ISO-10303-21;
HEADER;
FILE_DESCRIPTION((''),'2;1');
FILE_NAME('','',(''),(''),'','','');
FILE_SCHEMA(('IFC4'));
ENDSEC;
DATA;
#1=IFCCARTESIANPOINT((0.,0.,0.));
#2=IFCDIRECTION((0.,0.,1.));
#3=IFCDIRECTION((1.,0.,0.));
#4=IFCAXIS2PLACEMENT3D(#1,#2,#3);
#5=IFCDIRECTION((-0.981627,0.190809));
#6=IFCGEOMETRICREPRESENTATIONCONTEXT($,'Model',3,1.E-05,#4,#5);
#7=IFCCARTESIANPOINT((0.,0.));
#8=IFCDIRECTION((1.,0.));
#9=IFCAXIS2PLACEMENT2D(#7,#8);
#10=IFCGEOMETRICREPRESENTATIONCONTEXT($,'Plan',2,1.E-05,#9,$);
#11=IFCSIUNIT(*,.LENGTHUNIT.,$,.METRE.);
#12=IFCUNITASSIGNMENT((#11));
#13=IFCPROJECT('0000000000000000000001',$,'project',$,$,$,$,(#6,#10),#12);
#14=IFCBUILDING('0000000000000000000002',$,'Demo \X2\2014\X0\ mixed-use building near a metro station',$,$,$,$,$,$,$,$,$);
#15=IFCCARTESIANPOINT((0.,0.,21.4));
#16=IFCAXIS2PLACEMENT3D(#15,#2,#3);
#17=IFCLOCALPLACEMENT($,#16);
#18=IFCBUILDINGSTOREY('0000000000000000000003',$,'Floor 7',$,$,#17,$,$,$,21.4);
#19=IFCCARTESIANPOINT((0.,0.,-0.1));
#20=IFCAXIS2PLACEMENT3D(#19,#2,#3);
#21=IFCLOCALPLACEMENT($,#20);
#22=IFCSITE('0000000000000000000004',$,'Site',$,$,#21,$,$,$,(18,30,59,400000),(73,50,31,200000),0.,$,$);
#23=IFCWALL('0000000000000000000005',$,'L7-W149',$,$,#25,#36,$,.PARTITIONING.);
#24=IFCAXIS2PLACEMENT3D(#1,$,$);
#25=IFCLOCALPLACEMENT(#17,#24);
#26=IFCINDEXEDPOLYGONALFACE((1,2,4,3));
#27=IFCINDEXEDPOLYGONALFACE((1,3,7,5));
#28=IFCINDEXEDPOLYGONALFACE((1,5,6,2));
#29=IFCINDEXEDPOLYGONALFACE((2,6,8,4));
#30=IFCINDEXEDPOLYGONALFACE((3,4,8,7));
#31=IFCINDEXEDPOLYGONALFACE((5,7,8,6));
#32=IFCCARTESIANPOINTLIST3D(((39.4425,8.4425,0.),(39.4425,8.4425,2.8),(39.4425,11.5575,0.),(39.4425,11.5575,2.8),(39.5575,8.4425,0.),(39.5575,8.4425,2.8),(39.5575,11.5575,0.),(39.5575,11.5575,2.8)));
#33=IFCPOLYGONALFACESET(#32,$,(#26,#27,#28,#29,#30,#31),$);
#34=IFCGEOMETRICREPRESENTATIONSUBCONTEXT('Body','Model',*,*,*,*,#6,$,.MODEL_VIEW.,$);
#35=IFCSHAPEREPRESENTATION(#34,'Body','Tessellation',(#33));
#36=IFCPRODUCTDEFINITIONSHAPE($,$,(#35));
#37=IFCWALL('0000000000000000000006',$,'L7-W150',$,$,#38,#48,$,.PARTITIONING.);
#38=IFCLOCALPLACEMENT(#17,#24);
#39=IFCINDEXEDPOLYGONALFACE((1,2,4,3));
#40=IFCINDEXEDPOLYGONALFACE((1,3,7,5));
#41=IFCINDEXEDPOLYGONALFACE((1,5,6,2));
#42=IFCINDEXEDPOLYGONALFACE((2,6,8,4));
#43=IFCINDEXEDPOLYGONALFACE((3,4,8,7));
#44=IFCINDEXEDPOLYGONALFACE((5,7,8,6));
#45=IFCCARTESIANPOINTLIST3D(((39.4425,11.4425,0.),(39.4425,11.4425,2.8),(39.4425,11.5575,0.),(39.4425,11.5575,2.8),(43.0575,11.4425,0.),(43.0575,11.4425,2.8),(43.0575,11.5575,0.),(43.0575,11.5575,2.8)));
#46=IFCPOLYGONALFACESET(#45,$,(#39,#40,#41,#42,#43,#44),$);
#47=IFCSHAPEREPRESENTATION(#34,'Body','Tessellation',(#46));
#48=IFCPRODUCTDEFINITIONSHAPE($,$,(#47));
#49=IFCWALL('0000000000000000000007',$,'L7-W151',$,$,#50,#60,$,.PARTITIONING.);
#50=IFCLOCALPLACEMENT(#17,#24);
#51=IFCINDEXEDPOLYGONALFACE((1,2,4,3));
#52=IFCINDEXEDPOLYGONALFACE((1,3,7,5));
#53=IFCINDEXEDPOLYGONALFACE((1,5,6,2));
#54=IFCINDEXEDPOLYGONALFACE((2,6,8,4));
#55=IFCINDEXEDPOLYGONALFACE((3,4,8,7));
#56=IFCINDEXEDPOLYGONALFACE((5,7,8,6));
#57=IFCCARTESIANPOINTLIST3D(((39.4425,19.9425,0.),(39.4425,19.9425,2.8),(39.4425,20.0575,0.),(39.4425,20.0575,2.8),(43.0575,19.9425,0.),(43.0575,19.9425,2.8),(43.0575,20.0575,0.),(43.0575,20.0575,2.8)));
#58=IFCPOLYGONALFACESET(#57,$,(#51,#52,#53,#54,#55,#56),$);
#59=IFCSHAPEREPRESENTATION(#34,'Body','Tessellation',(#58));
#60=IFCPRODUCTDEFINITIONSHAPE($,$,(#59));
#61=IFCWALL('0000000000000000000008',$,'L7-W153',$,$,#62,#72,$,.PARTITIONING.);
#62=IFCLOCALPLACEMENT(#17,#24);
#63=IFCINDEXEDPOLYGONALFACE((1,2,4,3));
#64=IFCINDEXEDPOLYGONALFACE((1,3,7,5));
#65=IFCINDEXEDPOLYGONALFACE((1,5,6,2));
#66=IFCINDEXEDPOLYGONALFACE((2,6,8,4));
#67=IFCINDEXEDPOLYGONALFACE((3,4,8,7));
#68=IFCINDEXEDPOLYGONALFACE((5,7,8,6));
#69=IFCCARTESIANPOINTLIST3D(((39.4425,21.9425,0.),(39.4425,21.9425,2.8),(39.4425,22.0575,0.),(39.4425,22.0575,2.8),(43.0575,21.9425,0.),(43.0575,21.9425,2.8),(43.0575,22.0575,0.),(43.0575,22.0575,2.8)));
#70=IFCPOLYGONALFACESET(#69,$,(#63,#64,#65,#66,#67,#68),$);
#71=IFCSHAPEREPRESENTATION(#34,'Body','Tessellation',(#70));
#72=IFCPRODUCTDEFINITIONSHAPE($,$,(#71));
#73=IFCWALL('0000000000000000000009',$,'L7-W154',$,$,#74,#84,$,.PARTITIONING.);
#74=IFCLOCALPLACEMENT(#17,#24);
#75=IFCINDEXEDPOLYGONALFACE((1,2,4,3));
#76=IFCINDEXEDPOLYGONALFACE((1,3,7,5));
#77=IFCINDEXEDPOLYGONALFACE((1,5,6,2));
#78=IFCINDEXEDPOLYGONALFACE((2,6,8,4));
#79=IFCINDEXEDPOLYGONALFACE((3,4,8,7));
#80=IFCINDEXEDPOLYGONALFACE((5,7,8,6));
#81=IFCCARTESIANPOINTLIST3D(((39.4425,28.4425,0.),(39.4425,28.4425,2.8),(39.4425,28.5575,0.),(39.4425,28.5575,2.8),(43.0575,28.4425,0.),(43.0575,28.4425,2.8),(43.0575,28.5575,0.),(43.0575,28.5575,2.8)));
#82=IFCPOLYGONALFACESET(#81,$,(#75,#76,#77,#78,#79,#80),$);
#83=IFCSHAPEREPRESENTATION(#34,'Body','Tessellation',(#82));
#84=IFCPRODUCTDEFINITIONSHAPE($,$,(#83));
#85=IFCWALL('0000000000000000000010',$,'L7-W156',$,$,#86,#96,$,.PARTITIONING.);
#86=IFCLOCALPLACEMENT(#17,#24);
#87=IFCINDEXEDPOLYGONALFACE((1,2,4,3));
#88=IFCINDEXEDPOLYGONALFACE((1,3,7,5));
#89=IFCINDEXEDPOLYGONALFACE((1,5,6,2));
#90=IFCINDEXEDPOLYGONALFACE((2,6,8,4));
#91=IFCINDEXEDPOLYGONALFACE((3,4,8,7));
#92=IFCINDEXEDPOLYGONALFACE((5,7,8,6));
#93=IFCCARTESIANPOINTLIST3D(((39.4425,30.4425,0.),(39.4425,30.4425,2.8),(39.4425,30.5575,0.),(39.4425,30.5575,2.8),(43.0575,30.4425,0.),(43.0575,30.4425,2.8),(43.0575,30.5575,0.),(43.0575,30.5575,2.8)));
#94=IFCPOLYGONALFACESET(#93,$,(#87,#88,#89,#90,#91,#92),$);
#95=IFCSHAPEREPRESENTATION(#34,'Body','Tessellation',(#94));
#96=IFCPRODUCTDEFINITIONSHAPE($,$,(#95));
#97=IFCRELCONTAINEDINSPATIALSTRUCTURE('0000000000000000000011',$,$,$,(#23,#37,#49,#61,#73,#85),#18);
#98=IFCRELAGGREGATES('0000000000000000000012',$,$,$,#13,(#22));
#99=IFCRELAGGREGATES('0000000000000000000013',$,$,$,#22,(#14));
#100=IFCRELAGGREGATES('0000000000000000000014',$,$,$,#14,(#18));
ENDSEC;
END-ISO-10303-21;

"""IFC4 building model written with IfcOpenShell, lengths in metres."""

from ifc_helpers import new_model, si_unit, direction, frame, origin_with_axes, origin_2d_with_axis, place, context, subcontext, project, spatial, line, indexed_curve, outline, extrude, element, save


model = new_model("IFC4")

# Units and contexts
model_context = context("Model", 3, precision=1e-05, world=origin_with_axes(), true_north=direction((-0.981627, 0.190809)))
plan_context = context("Plan", 2, precision=1e-05, world=origin_2d_with_axis())
body_context = subcontext(model_context, "Body", "Model", "MODEL_VIEW")
ifc_project = project(units=[si_unit("LENGTHUNIT", "METRE")], contexts=[model_context, plan_context])

# Site, building, storey
site_placement = place(None, frame((0.0, 0.0, -0.1), z_axis=(0.0, 0.0, 1.0), x_axis=(1.0, 0.0, 0.0)))
site = spatial("IfcSite", under=ifc_project, at=site_placement, Name="Site", RefLatitude=(18, 30, 59, 400000), RefLongitude=(73, 50, 31, 200000), RefElevation=0.0)
building = spatial("IfcBuilding", under=site, Name="Demo — mixed-use building near a metro station")
storey_placement = place(None, frame((0.0, 0.0, 21.4), z_axis=(0.0, 0.0, 1.0), x_axis=(1.0, 0.0, 0.0)))
storey = spatial("IfcBuildingStorey", under=building, at=storey_placement, Name="Floor 7", Elevation=21.4)

# Walls
wall_1_placement = place(storey_placement, frame((0.0, 0.0, -21.4), z_axis=(0.0, 0.0, 1.0), x_axis=(1.0, 0.0, 0.0)))
element("IfcWall", 1, at=wall_1_placement, inside=storey, Name="L7-W149", PredefinedType="PARTITIONING", context=body_context, shape_type="SweptSolid", body=[
    extrude(outline(indexed_curve([(39.5575, 11.5575), (39.5575, 8.4425), (39.4425, 8.4425), (39.4425, 11.5575)], segments=[line(1, 2, 3, 4, 1)])), frame((0.0, 0.0, 21.4), z_axis=(0.0, 0.0, 1.0), x_axis=(1.0, 0.0, 0.0)), (0.0, 0.0, 1.0), 2.8),
])
wall_2_placement = place(storey_placement, frame((0.0, 0.0, -21.4), z_axis=(0.0, 0.0, 1.0), x_axis=(1.0, 0.0, 0.0)))
element("IfcWall", 2, at=wall_2_placement, inside=storey, Name="L7-W150", PredefinedType="PARTITIONING", context=body_context, shape_type="SweptSolid", body=[
    extrude(outline(indexed_curve([(39.4425, 11.5575), (43.0575, 11.5575), (43.0575, 11.4425), (39.4425, 11.4425)], segments=[line(1, 2, 3, 4, 1)])), frame((0.0, 0.0, 21.4), z_axis=(0.0, 0.0, 1.0), x_axis=(1.0, 0.0, 0.0)), (0.0, 0.0, 1.0), 2.8),
])
wall_3_placement = place(storey_placement, frame((0.0, 0.0, -21.4), z_axis=(0.0, 0.0, 1.0), x_axis=(1.0, 0.0, 0.0)))
element("IfcWall", 3, at=wall_3_placement, inside=storey, Name="L7-W151", PredefinedType="PARTITIONING", context=body_context, shape_type="SweptSolid", body=[
    extrude(outline(indexed_curve([(43.0575, 19.9425), (39.4425, 19.9425), (39.4425, 20.0575), (43.0575, 20.0575)], segments=[line(1, 2, 3, 4, 1)])), frame((0.0, 0.0, 21.4), z_axis=(0.0, 0.0, 1.0), x_axis=(1.0, 0.0, 0.0)), (0.0, 0.0, 1.0), 2.8),
])

# Walls
wall_4_placement = place(storey_placement, frame((0.0, 0.0, -21.4), z_axis=(0.0, 0.0, 1.0), x_axis=(1.0, 0.0, 0.0)))
element("IfcWall", 4, at=wall_4_placement, inside=storey, Name="L7-W153", PredefinedType="PARTITIONING", context=body_context, shape_type="SweptSolid", body=[
    extrude(outline(indexed_curve([(43.0575, 21.9425), (39.4425, 21.9425), (39.4425, 22.0575), (43.0575, 22.0575)], segments=[line(1, 2, 3, 4, 1)])), frame((0.0, 0.0, 21.4), z_axis=(0.0, 0.0, 1.0), x_axis=(1.0, 0.0, 0.0)), (0.0, 0.0, 1.0), 2.8),
])
wall_5_placement = place(storey_placement, frame((0.0, 0.0, -21.4), z_axis=(0.0, 0.0, 1.0), x_axis=(1.0, 0.0, 0.0)))
element("IfcWall", 5, at=wall_5_placement, inside=storey, Name="L7-W154", PredefinedType="PARTITIONING", context=body_context, shape_type="SweptSolid", body=[
    extrude(outline(indexed_curve([(43.0575, 28.4425), (39.4425, 28.4425), (39.4425, 28.5575), (43.0575, 28.5575)], segments=[line(1, 2, 3, 4, 1)])), frame((0.0, 0.0, 21.4), z_axis=(0.0, 0.0, 1.0), x_axis=(1.0, 0.0, 0.0)), (0.0, 0.0, 1.0), 2.8),
])

# Wall
wall_6_placement = place(storey_placement, frame((0.0, 0.0, -21.4), z_axis=(0.0, 0.0, 1.0), x_axis=(1.0, 0.0, 0.0)))
element("IfcWall", 6, at=wall_6_placement, inside=storey, Name="L7-W156", PredefinedType="PARTITIONING", context=body_context, shape_type="SweptSolid", body=[
    extrude(outline(indexed_curve([(43.0575, 30.4425), (39.4425, 30.4425), (39.4425, 30.5575), (43.0575, 30.5575)], segments=[line(1, 2, 3, 4, 1)])), frame((0.0, 0.0, 21.4), z_axis=(0.0, 0.0, 1.0), x_axis=(1.0, 0.0, 0.0)), (0.0, 0.0, 1.0), 2.8),
])

save(model, "model.ifc")
